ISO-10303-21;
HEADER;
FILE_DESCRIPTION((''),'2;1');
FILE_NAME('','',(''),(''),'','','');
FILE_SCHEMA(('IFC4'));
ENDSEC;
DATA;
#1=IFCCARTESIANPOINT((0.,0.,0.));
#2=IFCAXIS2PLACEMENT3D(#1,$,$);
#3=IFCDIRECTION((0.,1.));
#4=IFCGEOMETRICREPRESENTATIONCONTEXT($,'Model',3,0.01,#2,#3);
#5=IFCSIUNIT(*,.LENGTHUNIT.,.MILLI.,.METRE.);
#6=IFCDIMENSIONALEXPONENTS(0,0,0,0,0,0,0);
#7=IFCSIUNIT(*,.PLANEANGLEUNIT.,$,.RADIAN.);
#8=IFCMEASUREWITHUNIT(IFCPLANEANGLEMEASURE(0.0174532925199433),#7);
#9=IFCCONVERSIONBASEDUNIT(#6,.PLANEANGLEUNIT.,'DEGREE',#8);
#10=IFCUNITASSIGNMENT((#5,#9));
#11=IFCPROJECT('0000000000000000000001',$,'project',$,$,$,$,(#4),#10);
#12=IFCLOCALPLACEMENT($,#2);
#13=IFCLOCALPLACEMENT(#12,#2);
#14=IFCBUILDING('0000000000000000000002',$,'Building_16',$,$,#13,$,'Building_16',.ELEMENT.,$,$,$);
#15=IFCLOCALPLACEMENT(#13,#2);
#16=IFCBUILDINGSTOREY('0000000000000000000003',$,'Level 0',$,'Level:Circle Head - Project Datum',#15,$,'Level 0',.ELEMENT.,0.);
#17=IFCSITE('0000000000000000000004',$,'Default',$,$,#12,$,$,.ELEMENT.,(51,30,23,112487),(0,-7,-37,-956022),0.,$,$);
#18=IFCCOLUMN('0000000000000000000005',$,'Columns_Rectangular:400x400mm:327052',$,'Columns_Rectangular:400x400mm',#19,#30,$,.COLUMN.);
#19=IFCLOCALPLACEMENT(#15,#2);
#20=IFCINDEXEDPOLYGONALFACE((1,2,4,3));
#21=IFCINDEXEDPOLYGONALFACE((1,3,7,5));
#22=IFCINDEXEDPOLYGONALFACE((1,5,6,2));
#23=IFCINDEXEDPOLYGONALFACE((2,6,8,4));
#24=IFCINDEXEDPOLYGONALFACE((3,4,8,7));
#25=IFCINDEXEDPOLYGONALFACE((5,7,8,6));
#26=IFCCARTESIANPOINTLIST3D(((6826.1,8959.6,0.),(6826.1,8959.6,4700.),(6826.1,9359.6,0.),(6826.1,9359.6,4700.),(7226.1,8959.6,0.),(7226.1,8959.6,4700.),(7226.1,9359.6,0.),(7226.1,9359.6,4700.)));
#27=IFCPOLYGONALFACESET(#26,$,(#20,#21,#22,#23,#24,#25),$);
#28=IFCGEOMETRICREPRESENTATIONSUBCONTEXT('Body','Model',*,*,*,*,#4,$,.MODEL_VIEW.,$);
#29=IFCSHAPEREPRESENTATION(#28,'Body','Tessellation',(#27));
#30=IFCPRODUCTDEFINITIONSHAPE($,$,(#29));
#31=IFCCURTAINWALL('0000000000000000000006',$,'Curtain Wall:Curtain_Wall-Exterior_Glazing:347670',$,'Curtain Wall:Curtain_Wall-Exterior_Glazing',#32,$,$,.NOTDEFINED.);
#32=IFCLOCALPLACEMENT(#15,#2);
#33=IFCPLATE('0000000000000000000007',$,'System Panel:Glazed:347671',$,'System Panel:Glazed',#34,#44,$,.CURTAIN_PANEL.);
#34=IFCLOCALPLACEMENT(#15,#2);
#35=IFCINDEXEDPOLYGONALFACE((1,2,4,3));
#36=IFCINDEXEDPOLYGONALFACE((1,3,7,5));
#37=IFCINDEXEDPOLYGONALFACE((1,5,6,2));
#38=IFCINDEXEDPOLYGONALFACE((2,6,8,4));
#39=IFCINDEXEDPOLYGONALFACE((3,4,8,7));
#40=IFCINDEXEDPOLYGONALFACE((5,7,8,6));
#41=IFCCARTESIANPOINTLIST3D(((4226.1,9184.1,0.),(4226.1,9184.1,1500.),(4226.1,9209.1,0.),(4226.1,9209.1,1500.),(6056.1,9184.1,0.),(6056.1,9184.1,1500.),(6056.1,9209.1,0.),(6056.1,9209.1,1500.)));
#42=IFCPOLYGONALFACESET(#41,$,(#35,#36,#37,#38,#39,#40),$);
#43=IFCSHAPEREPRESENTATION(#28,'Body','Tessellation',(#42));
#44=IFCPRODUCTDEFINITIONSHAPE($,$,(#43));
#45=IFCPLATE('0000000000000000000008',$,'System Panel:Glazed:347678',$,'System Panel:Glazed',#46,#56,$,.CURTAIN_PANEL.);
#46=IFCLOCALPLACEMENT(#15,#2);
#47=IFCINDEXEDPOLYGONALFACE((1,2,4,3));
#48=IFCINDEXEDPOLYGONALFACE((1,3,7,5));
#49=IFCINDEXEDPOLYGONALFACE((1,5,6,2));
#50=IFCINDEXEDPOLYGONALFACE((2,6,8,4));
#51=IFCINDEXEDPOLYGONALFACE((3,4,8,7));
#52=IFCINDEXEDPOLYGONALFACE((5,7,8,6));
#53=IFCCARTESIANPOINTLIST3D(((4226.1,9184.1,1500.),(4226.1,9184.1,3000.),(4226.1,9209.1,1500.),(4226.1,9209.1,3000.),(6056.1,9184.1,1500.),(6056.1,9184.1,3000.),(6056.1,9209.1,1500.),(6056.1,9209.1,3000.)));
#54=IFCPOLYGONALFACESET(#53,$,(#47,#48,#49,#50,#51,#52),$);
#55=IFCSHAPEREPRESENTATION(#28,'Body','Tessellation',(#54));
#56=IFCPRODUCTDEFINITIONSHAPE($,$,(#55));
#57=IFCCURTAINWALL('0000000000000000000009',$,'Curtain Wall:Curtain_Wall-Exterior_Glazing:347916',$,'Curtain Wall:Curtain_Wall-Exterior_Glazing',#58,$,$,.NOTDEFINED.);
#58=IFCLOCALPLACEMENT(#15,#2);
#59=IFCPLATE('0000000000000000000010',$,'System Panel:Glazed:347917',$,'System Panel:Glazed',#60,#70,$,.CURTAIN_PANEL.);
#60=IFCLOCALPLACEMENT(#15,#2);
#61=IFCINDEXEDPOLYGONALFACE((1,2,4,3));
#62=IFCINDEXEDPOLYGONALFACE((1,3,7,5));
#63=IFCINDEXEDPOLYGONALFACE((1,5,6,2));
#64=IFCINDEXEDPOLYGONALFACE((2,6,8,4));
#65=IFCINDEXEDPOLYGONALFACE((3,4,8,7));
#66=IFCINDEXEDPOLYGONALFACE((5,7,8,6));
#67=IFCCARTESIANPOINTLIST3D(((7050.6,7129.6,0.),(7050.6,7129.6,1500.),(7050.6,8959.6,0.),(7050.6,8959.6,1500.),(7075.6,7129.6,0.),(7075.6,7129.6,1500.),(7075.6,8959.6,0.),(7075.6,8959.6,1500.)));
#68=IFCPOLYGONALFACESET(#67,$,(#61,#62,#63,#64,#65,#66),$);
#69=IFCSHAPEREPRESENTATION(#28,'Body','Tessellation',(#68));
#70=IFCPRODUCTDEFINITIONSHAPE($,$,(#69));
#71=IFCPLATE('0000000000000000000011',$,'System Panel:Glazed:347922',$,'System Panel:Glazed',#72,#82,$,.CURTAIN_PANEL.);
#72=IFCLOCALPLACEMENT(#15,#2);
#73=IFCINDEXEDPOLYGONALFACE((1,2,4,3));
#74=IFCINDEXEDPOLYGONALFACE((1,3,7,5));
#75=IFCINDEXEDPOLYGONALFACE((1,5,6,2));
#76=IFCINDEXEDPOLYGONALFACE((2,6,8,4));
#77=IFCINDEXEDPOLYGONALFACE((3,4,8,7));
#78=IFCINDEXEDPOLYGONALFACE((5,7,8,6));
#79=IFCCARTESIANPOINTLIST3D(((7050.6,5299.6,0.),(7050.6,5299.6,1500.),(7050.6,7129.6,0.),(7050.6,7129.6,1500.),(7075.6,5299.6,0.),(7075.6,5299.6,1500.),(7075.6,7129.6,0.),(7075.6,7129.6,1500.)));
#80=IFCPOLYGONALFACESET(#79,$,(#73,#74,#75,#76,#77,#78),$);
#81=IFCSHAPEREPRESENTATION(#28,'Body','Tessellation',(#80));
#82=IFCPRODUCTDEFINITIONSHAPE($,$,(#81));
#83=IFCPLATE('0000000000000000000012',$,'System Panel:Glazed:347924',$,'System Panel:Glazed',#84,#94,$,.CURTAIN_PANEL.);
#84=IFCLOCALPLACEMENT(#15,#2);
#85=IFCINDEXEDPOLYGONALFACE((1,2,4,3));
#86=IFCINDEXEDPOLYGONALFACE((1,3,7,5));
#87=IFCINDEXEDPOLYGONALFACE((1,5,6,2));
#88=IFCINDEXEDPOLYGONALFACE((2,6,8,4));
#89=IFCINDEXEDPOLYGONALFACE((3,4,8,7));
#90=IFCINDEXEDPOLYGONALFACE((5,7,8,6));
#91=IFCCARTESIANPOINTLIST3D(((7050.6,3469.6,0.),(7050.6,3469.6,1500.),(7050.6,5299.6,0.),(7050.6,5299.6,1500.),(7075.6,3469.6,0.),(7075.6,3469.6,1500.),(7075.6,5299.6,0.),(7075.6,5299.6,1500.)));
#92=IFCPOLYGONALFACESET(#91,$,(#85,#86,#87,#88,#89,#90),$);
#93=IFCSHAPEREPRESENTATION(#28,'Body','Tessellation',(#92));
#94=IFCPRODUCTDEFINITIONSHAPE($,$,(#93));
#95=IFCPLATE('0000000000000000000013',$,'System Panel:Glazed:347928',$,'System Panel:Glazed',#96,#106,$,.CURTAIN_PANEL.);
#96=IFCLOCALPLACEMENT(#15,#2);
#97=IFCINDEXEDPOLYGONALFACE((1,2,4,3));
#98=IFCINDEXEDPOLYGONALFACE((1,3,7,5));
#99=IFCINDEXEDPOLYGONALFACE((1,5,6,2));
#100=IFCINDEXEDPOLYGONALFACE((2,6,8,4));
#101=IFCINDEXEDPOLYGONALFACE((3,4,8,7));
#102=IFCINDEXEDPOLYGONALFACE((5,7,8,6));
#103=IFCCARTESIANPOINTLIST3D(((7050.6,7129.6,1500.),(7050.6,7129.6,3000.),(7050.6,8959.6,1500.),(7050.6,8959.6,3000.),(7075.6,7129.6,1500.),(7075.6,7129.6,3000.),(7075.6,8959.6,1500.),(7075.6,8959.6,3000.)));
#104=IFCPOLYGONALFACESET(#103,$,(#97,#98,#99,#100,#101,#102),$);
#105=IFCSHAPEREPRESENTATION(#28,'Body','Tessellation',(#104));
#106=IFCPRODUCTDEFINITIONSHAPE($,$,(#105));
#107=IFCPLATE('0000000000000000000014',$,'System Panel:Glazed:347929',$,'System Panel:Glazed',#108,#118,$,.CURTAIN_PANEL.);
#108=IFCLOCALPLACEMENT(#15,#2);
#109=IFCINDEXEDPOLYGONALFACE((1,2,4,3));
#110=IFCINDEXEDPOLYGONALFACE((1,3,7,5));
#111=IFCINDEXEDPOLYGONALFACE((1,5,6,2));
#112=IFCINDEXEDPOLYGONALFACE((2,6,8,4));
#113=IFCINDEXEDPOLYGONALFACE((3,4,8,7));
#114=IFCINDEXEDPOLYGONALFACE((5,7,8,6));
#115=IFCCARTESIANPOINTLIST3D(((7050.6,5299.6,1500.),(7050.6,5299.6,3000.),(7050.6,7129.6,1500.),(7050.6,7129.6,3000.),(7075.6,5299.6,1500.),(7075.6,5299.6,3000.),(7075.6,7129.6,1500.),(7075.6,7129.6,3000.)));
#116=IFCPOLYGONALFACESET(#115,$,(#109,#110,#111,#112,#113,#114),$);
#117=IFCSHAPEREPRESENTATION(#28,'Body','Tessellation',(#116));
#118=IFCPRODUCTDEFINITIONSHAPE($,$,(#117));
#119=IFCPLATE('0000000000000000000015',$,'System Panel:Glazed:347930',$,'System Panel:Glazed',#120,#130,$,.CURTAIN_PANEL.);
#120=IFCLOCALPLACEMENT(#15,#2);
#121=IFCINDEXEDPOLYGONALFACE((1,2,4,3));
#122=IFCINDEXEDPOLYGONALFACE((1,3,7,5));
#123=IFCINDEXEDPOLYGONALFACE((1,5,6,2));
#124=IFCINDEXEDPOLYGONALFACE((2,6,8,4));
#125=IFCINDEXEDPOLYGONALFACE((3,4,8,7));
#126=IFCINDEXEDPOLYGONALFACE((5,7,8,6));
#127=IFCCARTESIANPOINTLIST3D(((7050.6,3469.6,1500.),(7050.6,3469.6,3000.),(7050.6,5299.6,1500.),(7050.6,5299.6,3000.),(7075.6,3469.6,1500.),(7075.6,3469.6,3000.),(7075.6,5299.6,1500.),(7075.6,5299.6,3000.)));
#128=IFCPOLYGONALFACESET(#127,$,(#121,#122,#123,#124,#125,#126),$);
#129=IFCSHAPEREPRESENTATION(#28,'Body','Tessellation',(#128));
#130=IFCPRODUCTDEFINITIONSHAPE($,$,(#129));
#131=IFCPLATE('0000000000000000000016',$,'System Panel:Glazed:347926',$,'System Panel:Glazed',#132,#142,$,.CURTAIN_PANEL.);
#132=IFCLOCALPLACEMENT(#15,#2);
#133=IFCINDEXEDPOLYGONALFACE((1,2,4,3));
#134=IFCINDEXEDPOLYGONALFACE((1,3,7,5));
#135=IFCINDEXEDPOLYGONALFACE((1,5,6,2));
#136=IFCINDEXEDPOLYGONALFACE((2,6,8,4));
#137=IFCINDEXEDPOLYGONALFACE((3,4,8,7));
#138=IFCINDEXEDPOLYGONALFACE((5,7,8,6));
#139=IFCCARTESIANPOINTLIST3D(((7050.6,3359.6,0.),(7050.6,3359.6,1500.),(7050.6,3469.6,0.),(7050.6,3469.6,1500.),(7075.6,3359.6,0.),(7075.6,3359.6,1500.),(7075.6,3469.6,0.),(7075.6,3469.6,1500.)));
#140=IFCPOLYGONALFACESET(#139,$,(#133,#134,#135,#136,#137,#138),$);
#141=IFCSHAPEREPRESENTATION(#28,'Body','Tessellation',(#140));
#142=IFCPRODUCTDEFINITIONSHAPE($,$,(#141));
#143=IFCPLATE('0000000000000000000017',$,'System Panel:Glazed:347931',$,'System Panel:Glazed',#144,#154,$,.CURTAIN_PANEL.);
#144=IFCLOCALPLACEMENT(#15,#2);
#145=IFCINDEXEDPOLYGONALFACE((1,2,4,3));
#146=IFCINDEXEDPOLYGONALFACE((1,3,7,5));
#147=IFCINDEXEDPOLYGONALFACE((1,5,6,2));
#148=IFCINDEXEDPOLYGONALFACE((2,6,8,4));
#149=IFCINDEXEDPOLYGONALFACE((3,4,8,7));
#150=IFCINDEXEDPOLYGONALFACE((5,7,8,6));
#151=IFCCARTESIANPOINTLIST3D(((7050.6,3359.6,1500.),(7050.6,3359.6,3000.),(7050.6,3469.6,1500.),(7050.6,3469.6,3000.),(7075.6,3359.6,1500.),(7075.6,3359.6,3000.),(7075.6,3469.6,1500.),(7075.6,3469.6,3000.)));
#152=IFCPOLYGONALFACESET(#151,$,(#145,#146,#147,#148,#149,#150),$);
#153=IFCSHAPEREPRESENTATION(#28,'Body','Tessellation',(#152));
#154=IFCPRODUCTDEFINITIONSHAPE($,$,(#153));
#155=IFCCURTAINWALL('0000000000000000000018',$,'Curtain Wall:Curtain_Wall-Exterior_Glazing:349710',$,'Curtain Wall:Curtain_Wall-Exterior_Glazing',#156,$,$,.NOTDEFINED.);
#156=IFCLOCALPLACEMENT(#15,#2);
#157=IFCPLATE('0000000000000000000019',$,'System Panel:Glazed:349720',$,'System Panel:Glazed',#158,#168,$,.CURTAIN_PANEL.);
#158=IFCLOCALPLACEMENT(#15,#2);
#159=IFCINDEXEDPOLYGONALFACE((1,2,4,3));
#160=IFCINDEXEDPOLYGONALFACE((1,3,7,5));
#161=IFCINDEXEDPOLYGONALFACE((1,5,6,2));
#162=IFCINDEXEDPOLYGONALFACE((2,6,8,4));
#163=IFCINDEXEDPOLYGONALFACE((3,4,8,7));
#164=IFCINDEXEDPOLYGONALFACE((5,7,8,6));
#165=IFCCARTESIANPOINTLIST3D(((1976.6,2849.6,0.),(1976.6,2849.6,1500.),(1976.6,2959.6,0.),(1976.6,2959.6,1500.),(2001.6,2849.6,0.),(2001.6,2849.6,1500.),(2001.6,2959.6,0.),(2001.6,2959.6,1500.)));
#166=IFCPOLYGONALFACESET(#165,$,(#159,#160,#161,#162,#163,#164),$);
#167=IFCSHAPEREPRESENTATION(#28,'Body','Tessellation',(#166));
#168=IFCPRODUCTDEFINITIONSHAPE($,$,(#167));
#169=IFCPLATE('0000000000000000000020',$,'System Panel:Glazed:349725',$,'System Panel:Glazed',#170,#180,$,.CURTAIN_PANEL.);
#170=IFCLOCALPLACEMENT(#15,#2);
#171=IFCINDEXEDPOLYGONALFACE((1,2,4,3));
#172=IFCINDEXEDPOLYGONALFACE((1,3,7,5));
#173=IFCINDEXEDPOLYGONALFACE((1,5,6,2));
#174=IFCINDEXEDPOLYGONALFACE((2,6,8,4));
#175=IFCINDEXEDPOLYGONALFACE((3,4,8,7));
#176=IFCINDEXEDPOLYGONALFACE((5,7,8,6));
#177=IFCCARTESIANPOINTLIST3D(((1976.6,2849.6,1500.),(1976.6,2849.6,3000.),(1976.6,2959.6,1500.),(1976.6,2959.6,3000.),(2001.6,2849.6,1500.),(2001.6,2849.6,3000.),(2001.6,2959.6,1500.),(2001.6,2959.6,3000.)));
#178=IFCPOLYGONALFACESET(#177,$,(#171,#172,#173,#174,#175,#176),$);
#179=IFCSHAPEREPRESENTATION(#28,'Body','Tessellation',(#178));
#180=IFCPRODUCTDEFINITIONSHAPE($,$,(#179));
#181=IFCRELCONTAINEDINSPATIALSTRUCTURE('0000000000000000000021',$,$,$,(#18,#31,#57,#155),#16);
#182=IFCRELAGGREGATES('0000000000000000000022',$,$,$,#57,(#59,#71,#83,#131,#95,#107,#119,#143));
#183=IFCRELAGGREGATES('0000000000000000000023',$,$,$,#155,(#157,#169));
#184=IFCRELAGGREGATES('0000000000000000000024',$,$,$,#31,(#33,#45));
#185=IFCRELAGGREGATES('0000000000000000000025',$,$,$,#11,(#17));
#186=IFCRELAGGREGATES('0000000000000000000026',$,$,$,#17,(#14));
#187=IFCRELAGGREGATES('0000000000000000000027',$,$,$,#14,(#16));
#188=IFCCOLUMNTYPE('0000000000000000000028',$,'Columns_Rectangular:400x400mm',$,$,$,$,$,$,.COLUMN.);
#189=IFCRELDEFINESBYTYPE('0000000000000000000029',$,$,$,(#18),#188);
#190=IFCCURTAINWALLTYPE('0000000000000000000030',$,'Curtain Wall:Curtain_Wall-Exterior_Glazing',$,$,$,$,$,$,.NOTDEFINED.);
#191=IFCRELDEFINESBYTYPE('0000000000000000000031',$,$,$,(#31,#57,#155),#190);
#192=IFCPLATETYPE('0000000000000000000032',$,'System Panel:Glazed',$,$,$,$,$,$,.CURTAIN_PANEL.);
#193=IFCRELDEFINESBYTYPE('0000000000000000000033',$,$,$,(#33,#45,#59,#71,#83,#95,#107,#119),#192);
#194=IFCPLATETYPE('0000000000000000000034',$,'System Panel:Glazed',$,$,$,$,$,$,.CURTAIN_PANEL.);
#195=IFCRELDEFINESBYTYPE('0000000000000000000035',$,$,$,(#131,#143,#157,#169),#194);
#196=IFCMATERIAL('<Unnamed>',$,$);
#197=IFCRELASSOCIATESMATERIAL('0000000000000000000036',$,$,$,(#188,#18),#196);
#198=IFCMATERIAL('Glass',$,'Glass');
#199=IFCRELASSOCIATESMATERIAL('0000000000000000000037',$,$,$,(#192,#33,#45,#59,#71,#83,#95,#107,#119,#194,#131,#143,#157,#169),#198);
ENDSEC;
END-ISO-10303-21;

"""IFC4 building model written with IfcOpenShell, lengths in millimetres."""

from ifc_helpers import new_model, entity, si_unit, converted_unit, direction, frame, origin, place, context, subcontext, project, spatial, indexed_curve, outline, extrude, source, transform, mapped, material, type_object, type_shapes, element, aggregate, save


model = new_model("IFC4")

# Units and contexts
model_context = context("Model", 3, precision=0.01, world=origin(), true_north=direction((0.0, 1.0)))
body_context = subcontext(model_context, "Body", "Model", "MODEL_VIEW")
ifc_project = project(units=[si_unit("LENGTHUNIT", "METRE", prefix="MILLI"), converted_unit("PLANEANGLEUNIT", "DEGREE", entity("IfcPlaneAngleMeasure", 0.0174532925199433), si_unit("PLANEANGLEUNIT", "RADIAN"), dimensions=[0, 0, 0, 0, 0, 0, 0])], contexts=[model_context])

# Site, building, storey
site_placement = place(None, origin())
site = spatial("IfcSite", under=ifc_project, at=site_placement, Name="Default", CompositionType="ELEMENT", RefLatitude=(51, 30, 23, 112487), RefLongitude=(0, -7, -37, -956022), RefElevation=0.0)
building_placement = place(site_placement, origin())
building = spatial("IfcBuilding", under=site, at=building_placement, Name="Building_16", LongName="Building_16", CompositionType="ELEMENT")
storey_placement = place(building_placement, origin())
storey = spatial("IfcBuildingStorey", under=building, at=storey_placement, Name="Level 0", ObjectType="Level:Circle Head - Project Datum", LongName="Level 0", CompositionType="ELEMENT", Elevation=0.0)

# Column
ifc_material_1 = material(Name="<Unnamed>")
column_type = type_object("IfcColumnType", Name="Columns_Rectangular:400x400mm", PredefinedType="COLUMN", material=ifc_material_1)
shared_shape_1 = source(origin(), body_context, "Body", "SweptSolid", [
    extrude(outline(indexed_curve([(-200.0, -200.0), (200.0, -200.0), (200.0, 200.0), (-200.0, 200.0), (-200.0, -200.0)], self_intersect=False)), frame((0.0, 0.0, 0.0), z_axis=(0.0, 0.0, 1.0), x_axis=(-1.0, 0.0, 0.0)), (0.0, 0.0, 1.0), 4700.0),
])
type_shapes(column_type, [shared_shape_1])
column_placement = place(storey_placement, frame((7026.1, 9159.6, 0.0)))
element("IfcColumn", 1, at=column_placement, inside=storey, type_object=column_type, material=ifc_material_1, Name="Columns_Rectangular:400x400mm:327052", ObjectType="Columns_Rectangular:400x400mm", PredefinedType="COLUMN", context=body_context, shape_type="MappedRepresentation", body=[
    mapped(shared_shape_1, transform((0.0, 0.0, 0.0), scale=1.0)),
])

# Curtain walls, plates
curtain_wall_type = type_object("IfcCurtainWallType", Name="Curtain Wall:Curtain_Wall-Exterior_Glazing", PredefinedType="NOTDEFINED")
curtain_wall_1_placement = place(storey_placement, origin())
curtain_wall_1 = element("IfcCurtainWall", 2, at=curtain_wall_1_placement, inside=storey, type_object=curtain_wall_type, Name="Curtain Wall:Curtain_Wall-Exterior_Glazing:347670", ObjectType="Curtain Wall:Curtain_Wall-Exterior_Glazing", PredefinedType="NOTDEFINED")
ifc_material_2 = material(Name="Glass", Category="Glass")
plate_type_1 = type_object("IfcPlateType", Name="System Panel:Glazed", PredefinedType="CURTAIN_PANEL", material=ifc_material_2)
shared_shape_2 = source(origin(), body_context, "Body", "SweptSolid", [
    extrude(outline(indexed_curve([(-12.5, -915.0), (12.5, -915.0), (12.5, 915.0), (-12.5, 915.0), (-12.5, -915.0)], self_intersect=False)), frame((0.0, 37.0, 0.0), z_axis=(0.0, 0.0, 1.0), x_axis=(0.0, 1.0, 0.0)), (0.0, 0.0, 1.0), 1500.0),
])
type_shapes(plate_type_1, [shared_shape_2])
plate_1_placement = place(curtain_wall_1_placement, frame((5141.1, 9159.6, 0.0)))
plate_1 = element("IfcPlate", 3, at=plate_1_placement, type_object=plate_type_1, material=ifc_material_2, Name="System Panel:Glazed:347671", ObjectType="System Panel:Glazed", PredefinedType="CURTAIN_PANEL", context=body_context, shape_type="MappedRepresentation", body=[
    mapped(shared_shape_2, transform((0.0, 0.0, 0.0), scale=1.0)),
])
plate_2_placement = place(curtain_wall_1_placement, frame((5141.1, 9159.6, 1500.0)))
plate_2 = element("IfcPlate", 4, at=plate_2_placement, type_object=plate_type_1, material=ifc_material_2, Name="System Panel:Glazed:347678", ObjectType="System Panel:Glazed", PredefinedType="CURTAIN_PANEL", context=body_context, shape_type="MappedRepresentation", body=[
    mapped(shared_shape_2, transform((0.0, 0.0, 0.0), scale=1.0)),
])
curtain_wall_2_placement = place(storey_placement, origin())
curtain_wall_2 = element("IfcCurtainWall", 5, at=curtain_wall_2_placement, inside=storey, type_object=curtain_wall_type, Name="Curtain Wall:Curtain_Wall-Exterior_Glazing:347916", ObjectType="Curtain Wall:Curtain_Wall-Exterior_Glazing", PredefinedType="NOTDEFINED")
plate_3_placement = place(curtain_wall_2_placement, frame((7026.1, 8044.6, 0.0), z_axis=(0.0, 0.0, 1.0), x_axis=(0.0, -1.0, 0.0)))
plate_3 = element("IfcPlate", 6, at=plate_3_placement, type_object=plate_type_1, material=ifc_material_2, Name="System Panel:Glazed:347917", ObjectType="System Panel:Glazed", PredefinedType="CURTAIN_PANEL", context=body_context, shape_type="MappedRepresentation", body=[
    mapped(shared_shape_2, transform((0.0, 0.0, 0.0), scale=1.0)),
])
plate_4_placement = place(curtain_wall_2_placement, frame((7026.1, 6214.6, 0.0), z_axis=(0.0, 0.0, 1.0), x_axis=(0.0, -1.0, 0.0)))
plate_4 = element("IfcPlate", 7, at=plate_4_placement, type_object=plate_type_1, material=ifc_material_2, Name="System Panel:Glazed:347922", ObjectType="System Panel:Glazed", PredefinedType="CURTAIN_PANEL", context=body_context, shape_type="MappedRepresentation", body=[
    mapped(shared_shape_2, transform((0.0, 0.0, 0.0), scale=1.0)),
])
plate_5_placement = place(curtain_wall_2_placement, frame((7026.1, 4384.6, 0.0), z_axis=(0.0, 0.0, 1.0), x_axis=(0.0, -1.0, 0.0)))
plate_5 = element("IfcPlate", 8, at=plate_5_placement, type_object=plate_type_1, material=ifc_material_2, Name="System Panel:Glazed:347924", ObjectType="System Panel:Glazed", PredefinedType="CURTAIN_PANEL", context=body_context, shape_type="MappedRepresentation", body=[
    mapped(shared_shape_2, transform((0.0, 0.0, 0.0), scale=1.0)),
])
plate_6_placement = place(curtain_wall_2_placement, frame((7026.1, 8044.6, 1500.0), z_axis=(0.0, 0.0, 1.0), x_axis=(0.0, -1.0, 0.0)))
plate_6 = element("IfcPlate", 9, at=plate_6_placement, type_object=plate_type_1, material=ifc_material_2, Name="System Panel:Glazed:347928", ObjectType="System Panel:Glazed", PredefinedType="CURTAIN_PANEL", context=body_context, shape_type="MappedRepresentation", body=[
    mapped(shared_shape_2, transform((0.0, 0.0, 0.0), scale=1.0)),
])
plate_7_placement = place(curtain_wall_2_placement, frame((7026.1, 6214.6, 1500.0), z_axis=(0.0, 0.0, 1.0), x_axis=(0.0, -1.0, 0.0)))
plate_7 = element("IfcPlate", 10, at=plate_7_placement, type_object=plate_type_1, material=ifc_material_2, Name="System Panel:Glazed:347929", ObjectType="System Panel:Glazed", PredefinedType="CURTAIN_PANEL", context=body_context, shape_type="MappedRepresentation", body=[
    mapped(shared_shape_2, transform((0.0, 0.0, 0.0), scale=1.0)),
])
plate_8_placement = place(curtain_wall_2_placement, frame((7026.1, 4384.6, 1500.0), z_axis=(0.0, 0.0, 1.0), x_axis=(0.0, -1.0, 0.0)))
plate_8 = element("IfcPlate", 11, at=plate_8_placement, type_object=plate_type_1, material=ifc_material_2, Name="System Panel:Glazed:347930", ObjectType="System Panel:Glazed", PredefinedType="CURTAIN_PANEL", context=body_context, shape_type="MappedRepresentation", body=[
    mapped(shared_shape_2, transform((0.0, 0.0, 0.0), scale=1.0)),
])
plate_type_2 = type_object("IfcPlateType", Name="System Panel:Glazed", PredefinedType="CURTAIN_PANEL", material=ifc_material_2)
shared_shape_3 = source(origin(), body_context, "Body", "SweptSolid", [
    extrude(outline(indexed_curve([(-12.5, -55.0), (12.5, -55.0), (12.5, 55.0), (-12.5, 55.0), (-12.5, -55.0)], self_intersect=False)), frame((0.0, 37.0, 0.0), z_axis=(0.0, 0.0, 1.0), x_axis=(0.0, 1.0, 0.0)), (0.0, 0.0, 1.0), 1500.0),
])
type_shapes(plate_type_2, [shared_shape_3])
plate_9_placement = place(curtain_wall_2_placement, frame((7026.1, 3414.6, 0.0), z_axis=(0.0, 0.0, 1.0), x_axis=(0.0, -1.0, 0.0)))
plate_9 = element("IfcPlate", 12, at=plate_9_placement, type_object=plate_type_2, material=ifc_material_2, Name="System Panel:Glazed:347926", ObjectType="System Panel:Glazed", PredefinedType="CURTAIN_PANEL", context=body_context, shape_type="MappedRepresentation", body=[
    mapped(shared_shape_3, transform((0.0, 0.0, 0.0), scale=1.0)),
])
plate_10_placement = place(curtain_wall_2_placement, frame((7026.1, 3414.6, 1500.0), z_axis=(0.0, 0.0, 1.0), x_axis=(0.0, -1.0, 0.0)))
plate_10 = element("IfcPlate", 13, at=plate_10_placement, type_object=plate_type_2, material=ifc_material_2, Name="System Panel:Glazed:347931", ObjectType="System Panel:Glazed", PredefinedType="CURTAIN_PANEL", context=body_context, shape_type="MappedRepresentation", body=[
    mapped(shared_shape_3, transform((0.0, 0.0, 0.0), scale=1.0)),
])
curtain_wall_3_placement = place(storey_placement, origin())
curtain_wall_3 = element("IfcCurtainWall", 14, at=curtain_wall_3_placement, inside=storey, type_object=curtain_wall_type, Name="Curtain Wall:Curtain_Wall-Exterior_Glazing:349710", ObjectType="Curtain Wall:Curtain_Wall-Exterior_Glazing", PredefinedType="NOTDEFINED")
plate_11_placement = place(curtain_wall_3_placement, frame((2026.1, 2904.6, 0.0), z_axis=(0.0, 0.0, 1.0), x_axis=(0.0, 1.0, 0.0)))
plate_11 = element("IfcPlate", 15, at=plate_11_placement, type_object=plate_type_2, material=ifc_material_2, Name="System Panel:Glazed:349720", ObjectType="System Panel:Glazed", PredefinedType="CURTAIN_PANEL", context=body_context, shape_type="MappedRepresentation", body=[
    mapped(shared_shape_3, transform((0.0, 0.0, 0.0), scale=1.0)),
])
plate_12_placement = place(curtain_wall_3_placement, frame((2026.1, 2904.6, 1500.0), z_axis=(0.0, 0.0, 1.0), x_axis=(0.0, 1.0, 0.0)))
plate_12 = element("IfcPlate", 16, at=plate_12_placement, type_object=plate_type_2, material=ifc_material_2, Name="System Panel:Glazed:349725", ObjectType="System Panel:Glazed", PredefinedType="CURTAIN_PANEL", context=body_context, shape_type="MappedRepresentation", body=[
    mapped(shared_shape_3, transform((0.0, 0.0, 0.0), scale=1.0)),
])

aggregate(curtain_wall_2, [plate_3, plate_4, plate_5, plate_9, plate_6, plate_7, plate_8, plate_10])
aggregate(curtain_wall_3, [plate_11, plate_12])
aggregate(curtain_wall_1, [plate_1, plate_2])

save(model, "model.ifc")
